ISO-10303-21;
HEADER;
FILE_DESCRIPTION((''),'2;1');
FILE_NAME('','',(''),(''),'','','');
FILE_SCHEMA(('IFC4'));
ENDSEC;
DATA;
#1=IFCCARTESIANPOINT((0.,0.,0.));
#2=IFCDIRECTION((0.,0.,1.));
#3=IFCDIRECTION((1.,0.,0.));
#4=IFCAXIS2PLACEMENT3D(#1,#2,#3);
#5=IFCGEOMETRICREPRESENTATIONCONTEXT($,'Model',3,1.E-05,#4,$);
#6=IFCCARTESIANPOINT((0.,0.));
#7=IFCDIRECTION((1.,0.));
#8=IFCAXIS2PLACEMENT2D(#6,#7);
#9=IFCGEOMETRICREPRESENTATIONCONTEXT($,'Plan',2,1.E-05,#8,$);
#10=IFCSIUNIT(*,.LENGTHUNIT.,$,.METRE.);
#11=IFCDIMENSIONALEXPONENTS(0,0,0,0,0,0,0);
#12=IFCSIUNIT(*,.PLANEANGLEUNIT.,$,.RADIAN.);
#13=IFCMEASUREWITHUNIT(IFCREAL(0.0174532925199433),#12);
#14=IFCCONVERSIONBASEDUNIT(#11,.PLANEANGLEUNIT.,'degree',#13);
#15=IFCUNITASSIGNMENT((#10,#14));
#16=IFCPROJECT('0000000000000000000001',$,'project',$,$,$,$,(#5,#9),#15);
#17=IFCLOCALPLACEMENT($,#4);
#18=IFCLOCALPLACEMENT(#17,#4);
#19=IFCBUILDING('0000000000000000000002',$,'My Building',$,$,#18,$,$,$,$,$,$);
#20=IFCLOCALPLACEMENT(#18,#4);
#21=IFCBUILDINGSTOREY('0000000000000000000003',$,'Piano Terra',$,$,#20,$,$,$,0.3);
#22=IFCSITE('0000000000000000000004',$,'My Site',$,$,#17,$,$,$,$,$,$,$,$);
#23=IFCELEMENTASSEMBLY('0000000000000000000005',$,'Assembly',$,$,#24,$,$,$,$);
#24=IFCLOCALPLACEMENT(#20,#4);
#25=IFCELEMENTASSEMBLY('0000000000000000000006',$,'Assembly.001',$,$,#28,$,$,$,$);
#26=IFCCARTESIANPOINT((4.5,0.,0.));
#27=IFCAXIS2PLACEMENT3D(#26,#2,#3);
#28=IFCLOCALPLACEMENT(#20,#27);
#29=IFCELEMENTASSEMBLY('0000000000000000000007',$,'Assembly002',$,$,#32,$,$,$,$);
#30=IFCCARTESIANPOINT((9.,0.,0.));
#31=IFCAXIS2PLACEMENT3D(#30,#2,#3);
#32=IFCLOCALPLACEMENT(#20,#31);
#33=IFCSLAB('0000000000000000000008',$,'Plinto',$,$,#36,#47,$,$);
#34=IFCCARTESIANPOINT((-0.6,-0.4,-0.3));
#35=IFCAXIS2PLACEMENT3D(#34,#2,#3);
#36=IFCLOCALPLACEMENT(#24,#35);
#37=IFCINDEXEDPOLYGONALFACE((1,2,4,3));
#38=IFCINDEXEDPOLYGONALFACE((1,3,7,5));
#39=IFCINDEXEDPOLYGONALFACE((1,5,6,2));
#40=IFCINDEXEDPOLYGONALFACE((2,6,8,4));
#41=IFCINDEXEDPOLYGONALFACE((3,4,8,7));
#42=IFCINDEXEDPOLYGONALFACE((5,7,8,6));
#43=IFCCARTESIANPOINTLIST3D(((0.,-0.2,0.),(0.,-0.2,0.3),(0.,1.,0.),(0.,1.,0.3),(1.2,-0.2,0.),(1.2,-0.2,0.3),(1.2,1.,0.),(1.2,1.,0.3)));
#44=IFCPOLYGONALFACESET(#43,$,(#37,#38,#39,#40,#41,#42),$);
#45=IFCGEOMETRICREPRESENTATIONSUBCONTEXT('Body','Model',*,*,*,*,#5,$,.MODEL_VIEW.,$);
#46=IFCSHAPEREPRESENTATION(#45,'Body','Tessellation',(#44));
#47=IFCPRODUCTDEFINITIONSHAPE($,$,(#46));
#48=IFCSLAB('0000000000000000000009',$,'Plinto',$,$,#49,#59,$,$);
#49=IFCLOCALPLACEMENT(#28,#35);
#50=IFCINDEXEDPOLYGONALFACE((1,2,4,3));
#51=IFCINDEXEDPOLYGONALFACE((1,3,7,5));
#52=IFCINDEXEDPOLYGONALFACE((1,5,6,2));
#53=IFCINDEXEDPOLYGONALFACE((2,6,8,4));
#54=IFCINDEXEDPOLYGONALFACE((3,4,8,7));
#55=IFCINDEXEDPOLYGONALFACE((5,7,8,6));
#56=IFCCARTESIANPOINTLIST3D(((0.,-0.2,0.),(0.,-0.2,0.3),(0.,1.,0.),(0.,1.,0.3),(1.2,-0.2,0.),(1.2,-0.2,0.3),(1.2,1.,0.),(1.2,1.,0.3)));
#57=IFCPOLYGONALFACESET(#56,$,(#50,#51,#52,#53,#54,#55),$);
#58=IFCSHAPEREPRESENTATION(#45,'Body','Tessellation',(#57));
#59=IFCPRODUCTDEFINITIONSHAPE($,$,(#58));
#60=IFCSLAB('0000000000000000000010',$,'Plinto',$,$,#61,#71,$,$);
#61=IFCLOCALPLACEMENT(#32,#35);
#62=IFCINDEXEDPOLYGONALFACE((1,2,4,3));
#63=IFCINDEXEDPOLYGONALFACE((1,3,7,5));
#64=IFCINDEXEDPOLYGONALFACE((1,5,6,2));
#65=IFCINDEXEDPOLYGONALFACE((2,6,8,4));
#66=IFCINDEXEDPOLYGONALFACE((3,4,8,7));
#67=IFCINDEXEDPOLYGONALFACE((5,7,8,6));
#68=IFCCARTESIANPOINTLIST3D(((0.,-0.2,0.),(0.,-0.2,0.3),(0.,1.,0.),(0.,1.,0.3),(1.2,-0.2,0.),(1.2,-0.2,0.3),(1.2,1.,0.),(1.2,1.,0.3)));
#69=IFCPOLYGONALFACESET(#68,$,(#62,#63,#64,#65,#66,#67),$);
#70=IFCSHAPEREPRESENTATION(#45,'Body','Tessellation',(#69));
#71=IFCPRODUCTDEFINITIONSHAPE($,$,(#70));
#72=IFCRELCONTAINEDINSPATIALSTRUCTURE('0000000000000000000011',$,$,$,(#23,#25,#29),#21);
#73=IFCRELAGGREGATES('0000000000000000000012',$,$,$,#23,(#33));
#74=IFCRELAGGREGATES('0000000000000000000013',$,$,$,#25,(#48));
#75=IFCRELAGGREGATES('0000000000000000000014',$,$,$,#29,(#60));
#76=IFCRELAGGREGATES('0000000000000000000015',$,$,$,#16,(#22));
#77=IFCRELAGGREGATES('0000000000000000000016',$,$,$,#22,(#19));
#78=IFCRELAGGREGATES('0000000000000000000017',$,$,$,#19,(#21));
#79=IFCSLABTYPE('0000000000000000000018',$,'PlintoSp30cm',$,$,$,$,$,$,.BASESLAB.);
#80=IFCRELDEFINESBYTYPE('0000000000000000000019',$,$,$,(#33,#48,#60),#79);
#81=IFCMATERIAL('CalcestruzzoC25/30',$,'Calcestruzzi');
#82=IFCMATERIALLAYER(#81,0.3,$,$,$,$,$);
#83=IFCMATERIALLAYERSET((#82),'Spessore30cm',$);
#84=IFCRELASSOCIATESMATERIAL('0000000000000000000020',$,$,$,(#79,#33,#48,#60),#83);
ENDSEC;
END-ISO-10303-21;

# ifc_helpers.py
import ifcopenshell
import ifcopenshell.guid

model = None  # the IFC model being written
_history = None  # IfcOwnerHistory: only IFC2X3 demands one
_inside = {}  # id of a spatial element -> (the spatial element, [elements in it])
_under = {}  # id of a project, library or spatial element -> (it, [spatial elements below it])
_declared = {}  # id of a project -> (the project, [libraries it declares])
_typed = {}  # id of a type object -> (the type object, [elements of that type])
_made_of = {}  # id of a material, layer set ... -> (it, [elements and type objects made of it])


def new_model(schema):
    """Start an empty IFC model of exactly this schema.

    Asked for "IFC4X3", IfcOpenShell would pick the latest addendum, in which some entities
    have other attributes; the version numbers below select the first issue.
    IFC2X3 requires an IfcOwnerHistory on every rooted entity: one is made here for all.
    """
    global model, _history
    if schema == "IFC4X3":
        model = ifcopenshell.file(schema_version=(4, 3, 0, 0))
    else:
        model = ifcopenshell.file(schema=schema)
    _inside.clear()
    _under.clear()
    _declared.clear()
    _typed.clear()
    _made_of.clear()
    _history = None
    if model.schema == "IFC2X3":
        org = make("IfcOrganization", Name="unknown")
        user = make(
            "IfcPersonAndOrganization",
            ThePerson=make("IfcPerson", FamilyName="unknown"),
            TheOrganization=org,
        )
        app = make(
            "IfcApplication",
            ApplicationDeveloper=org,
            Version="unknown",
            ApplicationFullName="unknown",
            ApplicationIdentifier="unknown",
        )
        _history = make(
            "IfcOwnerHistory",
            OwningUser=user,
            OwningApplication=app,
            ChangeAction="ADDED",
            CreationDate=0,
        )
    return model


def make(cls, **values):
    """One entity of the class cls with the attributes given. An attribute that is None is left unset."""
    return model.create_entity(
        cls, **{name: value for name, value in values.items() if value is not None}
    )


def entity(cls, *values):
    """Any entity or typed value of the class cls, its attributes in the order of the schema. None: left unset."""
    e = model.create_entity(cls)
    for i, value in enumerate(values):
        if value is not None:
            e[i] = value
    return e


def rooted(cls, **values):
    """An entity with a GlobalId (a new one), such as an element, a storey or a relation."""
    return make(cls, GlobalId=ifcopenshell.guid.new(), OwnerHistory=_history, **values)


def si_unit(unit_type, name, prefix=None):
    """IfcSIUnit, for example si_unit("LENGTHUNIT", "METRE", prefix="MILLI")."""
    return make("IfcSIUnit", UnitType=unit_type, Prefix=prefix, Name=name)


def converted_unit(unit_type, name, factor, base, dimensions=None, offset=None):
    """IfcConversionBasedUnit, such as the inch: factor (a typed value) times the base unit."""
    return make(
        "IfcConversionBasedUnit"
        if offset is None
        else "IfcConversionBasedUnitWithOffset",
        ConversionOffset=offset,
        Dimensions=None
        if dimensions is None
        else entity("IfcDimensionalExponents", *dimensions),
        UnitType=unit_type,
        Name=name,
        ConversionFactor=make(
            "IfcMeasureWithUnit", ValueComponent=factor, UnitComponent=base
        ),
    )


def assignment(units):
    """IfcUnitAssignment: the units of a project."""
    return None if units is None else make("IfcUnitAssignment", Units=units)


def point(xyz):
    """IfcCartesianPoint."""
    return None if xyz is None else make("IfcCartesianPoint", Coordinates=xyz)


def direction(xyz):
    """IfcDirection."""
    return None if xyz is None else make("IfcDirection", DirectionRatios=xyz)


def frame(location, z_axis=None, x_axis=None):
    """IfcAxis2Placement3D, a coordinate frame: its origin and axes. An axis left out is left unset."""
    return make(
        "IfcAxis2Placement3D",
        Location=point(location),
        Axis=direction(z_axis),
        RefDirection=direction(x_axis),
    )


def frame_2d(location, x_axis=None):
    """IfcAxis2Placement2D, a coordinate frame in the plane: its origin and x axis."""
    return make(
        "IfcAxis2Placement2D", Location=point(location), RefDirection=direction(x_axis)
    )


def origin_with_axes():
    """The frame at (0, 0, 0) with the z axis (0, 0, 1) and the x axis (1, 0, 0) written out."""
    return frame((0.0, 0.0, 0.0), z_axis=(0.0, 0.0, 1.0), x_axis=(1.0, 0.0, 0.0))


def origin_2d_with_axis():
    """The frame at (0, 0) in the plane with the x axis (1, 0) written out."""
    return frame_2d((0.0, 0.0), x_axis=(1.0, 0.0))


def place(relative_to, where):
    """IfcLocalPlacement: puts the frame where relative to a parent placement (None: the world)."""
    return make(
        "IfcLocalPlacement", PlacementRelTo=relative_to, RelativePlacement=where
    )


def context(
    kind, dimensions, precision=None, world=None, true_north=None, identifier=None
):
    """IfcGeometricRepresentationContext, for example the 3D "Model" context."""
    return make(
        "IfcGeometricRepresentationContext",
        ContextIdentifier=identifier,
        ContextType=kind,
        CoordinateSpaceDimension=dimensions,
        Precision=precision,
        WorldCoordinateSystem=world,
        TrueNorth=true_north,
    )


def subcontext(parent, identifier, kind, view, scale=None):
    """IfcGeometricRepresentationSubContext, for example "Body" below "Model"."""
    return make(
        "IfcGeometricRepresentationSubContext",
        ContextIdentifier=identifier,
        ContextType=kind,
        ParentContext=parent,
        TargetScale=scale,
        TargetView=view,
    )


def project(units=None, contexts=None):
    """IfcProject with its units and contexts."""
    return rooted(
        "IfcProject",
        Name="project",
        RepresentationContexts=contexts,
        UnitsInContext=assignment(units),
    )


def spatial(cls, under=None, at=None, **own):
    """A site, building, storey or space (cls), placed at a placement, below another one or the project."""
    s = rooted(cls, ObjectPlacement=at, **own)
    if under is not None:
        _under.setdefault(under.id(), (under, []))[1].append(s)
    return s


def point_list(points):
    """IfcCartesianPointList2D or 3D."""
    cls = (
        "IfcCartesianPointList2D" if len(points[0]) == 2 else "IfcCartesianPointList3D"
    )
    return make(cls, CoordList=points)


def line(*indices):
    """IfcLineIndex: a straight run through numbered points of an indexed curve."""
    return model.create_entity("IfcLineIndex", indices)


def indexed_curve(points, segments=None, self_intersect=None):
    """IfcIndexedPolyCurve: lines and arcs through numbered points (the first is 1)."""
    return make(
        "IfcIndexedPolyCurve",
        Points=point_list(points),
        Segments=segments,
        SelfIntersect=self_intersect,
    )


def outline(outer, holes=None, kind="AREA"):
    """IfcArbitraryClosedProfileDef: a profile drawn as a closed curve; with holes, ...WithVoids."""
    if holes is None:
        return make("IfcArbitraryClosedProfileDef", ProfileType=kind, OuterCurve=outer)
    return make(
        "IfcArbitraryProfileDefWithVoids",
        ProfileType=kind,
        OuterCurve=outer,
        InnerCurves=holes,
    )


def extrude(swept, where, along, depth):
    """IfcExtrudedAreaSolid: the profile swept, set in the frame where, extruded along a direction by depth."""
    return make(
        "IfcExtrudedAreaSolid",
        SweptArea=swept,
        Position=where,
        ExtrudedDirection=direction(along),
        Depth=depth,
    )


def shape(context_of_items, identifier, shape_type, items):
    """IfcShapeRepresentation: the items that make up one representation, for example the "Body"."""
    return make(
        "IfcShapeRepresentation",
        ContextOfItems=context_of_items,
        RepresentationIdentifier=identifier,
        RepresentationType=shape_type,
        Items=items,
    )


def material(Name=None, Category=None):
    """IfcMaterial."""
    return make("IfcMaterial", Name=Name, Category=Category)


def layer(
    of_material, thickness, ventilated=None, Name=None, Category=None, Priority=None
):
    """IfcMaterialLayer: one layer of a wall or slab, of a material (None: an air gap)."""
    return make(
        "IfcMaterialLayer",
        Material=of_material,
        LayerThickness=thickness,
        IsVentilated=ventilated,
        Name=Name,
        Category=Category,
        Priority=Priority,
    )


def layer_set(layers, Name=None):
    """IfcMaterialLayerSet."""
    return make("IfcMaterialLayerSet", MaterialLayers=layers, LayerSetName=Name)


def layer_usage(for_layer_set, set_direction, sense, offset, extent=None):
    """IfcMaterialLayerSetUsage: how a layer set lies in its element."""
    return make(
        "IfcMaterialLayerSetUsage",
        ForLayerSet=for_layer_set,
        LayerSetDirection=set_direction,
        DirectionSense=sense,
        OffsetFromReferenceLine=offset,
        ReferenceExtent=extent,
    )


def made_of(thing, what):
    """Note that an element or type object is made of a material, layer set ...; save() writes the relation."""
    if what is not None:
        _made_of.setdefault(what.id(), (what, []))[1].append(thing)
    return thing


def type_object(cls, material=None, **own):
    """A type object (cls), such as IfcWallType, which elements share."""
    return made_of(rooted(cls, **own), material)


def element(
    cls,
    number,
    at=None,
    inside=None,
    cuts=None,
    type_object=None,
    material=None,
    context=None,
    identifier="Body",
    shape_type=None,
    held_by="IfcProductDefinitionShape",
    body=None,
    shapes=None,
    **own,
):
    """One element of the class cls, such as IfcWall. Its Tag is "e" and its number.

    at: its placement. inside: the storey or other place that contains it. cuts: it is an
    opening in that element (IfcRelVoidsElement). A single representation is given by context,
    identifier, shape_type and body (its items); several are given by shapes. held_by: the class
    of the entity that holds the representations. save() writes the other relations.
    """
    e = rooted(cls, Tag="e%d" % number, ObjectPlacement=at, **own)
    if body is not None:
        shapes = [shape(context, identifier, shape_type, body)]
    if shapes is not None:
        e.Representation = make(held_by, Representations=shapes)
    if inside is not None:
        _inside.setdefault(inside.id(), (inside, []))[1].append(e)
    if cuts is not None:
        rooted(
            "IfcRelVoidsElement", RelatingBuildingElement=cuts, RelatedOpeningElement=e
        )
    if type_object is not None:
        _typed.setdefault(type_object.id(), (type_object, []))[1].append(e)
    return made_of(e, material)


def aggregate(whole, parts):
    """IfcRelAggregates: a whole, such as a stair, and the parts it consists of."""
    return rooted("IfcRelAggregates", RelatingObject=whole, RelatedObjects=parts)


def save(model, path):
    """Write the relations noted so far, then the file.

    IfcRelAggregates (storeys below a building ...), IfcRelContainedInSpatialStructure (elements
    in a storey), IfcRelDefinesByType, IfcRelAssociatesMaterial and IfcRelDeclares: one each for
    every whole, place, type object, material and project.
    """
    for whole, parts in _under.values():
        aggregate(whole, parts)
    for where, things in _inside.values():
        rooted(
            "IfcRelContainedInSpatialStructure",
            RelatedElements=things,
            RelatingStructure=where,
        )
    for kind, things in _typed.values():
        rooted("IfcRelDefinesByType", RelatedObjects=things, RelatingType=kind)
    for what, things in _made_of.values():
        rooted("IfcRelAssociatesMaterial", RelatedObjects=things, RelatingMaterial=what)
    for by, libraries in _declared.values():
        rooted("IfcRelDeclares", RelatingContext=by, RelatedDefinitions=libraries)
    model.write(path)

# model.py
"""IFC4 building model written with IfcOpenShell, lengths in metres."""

from ifc_helpers import new_model, entity, si_unit, converted_unit, frame, origin_with_axes, origin_2d_with_axis, place, context, subcontext, project, spatial, line, indexed_curve, outline, extrude, material, layer, layer_set, layer_usage, type_object, element, aggregate, save


model = new_model("IFC4")

# Units and contexts
model_context = context("Model", 3, precision=1e-05, world=origin_with_axes())
plan_context = context("Plan", 2, precision=1e-05, world=origin_2d_with_axis())
body_context = subcontext(model_context, "Body", "Model", "MODEL_VIEW")
ifc_project = project(units=[si_unit("LENGTHUNIT", "METRE"), converted_unit("PLANEANGLEUNIT", "degree", entity("IfcReal", 0.0174532925199433), si_unit("PLANEANGLEUNIT", "RADIAN"), dimensions=[0, 0, 0, 0, 0, 0, 0])], contexts=[model_context, plan_context])

# Site, building, storey
site_placement = place(None, origin_with_axes())
site = spatial("IfcSite", under=ifc_project, at=site_placement, Name="My Site")
building_placement = place(site_placement, origin_with_axes())
building = spatial("IfcBuilding", under=site, at=building_placement, Name="My Building")
storey_placement = place(building_placement, origin_with_axes())
storey = spatial("IfcBuildingStorey", under=building, at=storey_placement, Name="Piano Terra", Elevation=0.3)

# Element assemblies
assembly_1_placement = place(storey_placement, origin_with_axes())
assembly_1 = element("IfcElementAssembly", 1, at=assembly_1_placement, inside=storey, Name="Assembly")
assembly_2_placement = place(storey_placement, frame((4.5, 0.0, 0.0), z_axis=(0.0, 0.0, 1.0), x_axis=(1.0, 0.0, 0.0)))
assembly_2 = element("IfcElementAssembly", 2, at=assembly_2_placement, inside=storey, Name="Assembly.001")
assembly_3_placement = place(storey_placement, frame((9.0, 0.0, 0.0), z_axis=(0.0, 0.0, 1.0), x_axis=(1.0, 0.0, 0.0)))
assembly_3 = element("IfcElementAssembly", 3, at=assembly_3_placement, inside=storey, Name="Assembly002")

# Slabs
ifc_material_1 = material(Name="CalcestruzzoC25/30", Category="Calcestruzzi")
ifc_layer = layer(ifc_material_1, 0.3)
ifc_layer_set = layer_set([ifc_layer], Name="Spessore30cm")
ifc_layer_usage_1 = layer_usage(ifc_layer_set, "AXIS3", "POSITIVE", 0.0)
slab_type = type_object("IfcSlabType", Name="PlintoSp30cm", PredefinedType="BASESLAB", material=ifc_layer_set)
slab_1_placement = place(assembly_1_placement, frame((-0.6, -0.4, -0.3), z_axis=(0.0, 0.0, 1.0), x_axis=(1.0, 0.0, 0.0)))
slab_1 = element("IfcSlab", 4, at=slab_1_placement, type_object=slab_type, material=ifc_layer_usage_1, Name="Plinto", context=body_context, shape_type="SweptSolid", body=[
    extrude(outline(indexed_curve([(0.0, 1.0), (1.2, 1.0), (1.2, -0.2), (0.0, -0.2)], segments=[line(4, 1), line(1, 2), line(2, 3), line(3, 4)], self_intersect=False)), None, (0.0, 0.0, 1.0), 0.3),
])
aggregate(assembly_1, [slab_1])
ifc_layer_usage_2 = layer_usage(ifc_layer_set, "AXIS3", "POSITIVE", 0.0)
slab_2_placement = place(assembly_2_placement, frame((-0.6, -0.4, -0.3), z_axis=(0.0, 0.0, 1.0), x_axis=(1.0, 0.0, 0.0)))
slab_2 = element("IfcSlab", 5, at=slab_2_placement, type_object=slab_type, material=ifc_layer_usage_2, Name="Plinto", context=body_context, shape_type="SweptSolid", body=[
    extrude(outline(indexed_curve([(0.0, 1.0), (1.2, 1.0), (1.2, -0.2), (0.0, -0.2)], segments=[line(4, 1), line(1, 2), line(2, 3), line(3, 4)], self_intersect=False)), None, (0.0, 0.0, 1.0), 0.3),
])
aggregate(assembly_2, [slab_2])
ifc_layer_usage_3 = layer_usage(ifc_layer_set, "AXIS3", "POSITIVE", 0.0)
slab_3_placement = place(assembly_3_placement, frame((-0.6, -0.4, -0.3), z_axis=(0.0, 0.0, 1.0), x_axis=(1.0, 0.0, 0.0)))
slab_3 = element("IfcSlab", 6, at=slab_3_placement, type_object=slab_type, material=ifc_layer_usage_3, Name="Plinto", context=body_context, shape_type="SweptSolid", body=[
    extrude(outline(indexed_curve([(0.0, 1.0), (1.2, 1.0), (1.2, -0.2), (0.0, -0.2)], segments=[line(4, 1), line(1, 2), line(2, 3), line(3, 4)], self_intersect=False)), None, (0.0, 0.0, 1.0), 0.3),
])
aggregate(assembly_3, [slab_3])

save(model, "model.ifc")
